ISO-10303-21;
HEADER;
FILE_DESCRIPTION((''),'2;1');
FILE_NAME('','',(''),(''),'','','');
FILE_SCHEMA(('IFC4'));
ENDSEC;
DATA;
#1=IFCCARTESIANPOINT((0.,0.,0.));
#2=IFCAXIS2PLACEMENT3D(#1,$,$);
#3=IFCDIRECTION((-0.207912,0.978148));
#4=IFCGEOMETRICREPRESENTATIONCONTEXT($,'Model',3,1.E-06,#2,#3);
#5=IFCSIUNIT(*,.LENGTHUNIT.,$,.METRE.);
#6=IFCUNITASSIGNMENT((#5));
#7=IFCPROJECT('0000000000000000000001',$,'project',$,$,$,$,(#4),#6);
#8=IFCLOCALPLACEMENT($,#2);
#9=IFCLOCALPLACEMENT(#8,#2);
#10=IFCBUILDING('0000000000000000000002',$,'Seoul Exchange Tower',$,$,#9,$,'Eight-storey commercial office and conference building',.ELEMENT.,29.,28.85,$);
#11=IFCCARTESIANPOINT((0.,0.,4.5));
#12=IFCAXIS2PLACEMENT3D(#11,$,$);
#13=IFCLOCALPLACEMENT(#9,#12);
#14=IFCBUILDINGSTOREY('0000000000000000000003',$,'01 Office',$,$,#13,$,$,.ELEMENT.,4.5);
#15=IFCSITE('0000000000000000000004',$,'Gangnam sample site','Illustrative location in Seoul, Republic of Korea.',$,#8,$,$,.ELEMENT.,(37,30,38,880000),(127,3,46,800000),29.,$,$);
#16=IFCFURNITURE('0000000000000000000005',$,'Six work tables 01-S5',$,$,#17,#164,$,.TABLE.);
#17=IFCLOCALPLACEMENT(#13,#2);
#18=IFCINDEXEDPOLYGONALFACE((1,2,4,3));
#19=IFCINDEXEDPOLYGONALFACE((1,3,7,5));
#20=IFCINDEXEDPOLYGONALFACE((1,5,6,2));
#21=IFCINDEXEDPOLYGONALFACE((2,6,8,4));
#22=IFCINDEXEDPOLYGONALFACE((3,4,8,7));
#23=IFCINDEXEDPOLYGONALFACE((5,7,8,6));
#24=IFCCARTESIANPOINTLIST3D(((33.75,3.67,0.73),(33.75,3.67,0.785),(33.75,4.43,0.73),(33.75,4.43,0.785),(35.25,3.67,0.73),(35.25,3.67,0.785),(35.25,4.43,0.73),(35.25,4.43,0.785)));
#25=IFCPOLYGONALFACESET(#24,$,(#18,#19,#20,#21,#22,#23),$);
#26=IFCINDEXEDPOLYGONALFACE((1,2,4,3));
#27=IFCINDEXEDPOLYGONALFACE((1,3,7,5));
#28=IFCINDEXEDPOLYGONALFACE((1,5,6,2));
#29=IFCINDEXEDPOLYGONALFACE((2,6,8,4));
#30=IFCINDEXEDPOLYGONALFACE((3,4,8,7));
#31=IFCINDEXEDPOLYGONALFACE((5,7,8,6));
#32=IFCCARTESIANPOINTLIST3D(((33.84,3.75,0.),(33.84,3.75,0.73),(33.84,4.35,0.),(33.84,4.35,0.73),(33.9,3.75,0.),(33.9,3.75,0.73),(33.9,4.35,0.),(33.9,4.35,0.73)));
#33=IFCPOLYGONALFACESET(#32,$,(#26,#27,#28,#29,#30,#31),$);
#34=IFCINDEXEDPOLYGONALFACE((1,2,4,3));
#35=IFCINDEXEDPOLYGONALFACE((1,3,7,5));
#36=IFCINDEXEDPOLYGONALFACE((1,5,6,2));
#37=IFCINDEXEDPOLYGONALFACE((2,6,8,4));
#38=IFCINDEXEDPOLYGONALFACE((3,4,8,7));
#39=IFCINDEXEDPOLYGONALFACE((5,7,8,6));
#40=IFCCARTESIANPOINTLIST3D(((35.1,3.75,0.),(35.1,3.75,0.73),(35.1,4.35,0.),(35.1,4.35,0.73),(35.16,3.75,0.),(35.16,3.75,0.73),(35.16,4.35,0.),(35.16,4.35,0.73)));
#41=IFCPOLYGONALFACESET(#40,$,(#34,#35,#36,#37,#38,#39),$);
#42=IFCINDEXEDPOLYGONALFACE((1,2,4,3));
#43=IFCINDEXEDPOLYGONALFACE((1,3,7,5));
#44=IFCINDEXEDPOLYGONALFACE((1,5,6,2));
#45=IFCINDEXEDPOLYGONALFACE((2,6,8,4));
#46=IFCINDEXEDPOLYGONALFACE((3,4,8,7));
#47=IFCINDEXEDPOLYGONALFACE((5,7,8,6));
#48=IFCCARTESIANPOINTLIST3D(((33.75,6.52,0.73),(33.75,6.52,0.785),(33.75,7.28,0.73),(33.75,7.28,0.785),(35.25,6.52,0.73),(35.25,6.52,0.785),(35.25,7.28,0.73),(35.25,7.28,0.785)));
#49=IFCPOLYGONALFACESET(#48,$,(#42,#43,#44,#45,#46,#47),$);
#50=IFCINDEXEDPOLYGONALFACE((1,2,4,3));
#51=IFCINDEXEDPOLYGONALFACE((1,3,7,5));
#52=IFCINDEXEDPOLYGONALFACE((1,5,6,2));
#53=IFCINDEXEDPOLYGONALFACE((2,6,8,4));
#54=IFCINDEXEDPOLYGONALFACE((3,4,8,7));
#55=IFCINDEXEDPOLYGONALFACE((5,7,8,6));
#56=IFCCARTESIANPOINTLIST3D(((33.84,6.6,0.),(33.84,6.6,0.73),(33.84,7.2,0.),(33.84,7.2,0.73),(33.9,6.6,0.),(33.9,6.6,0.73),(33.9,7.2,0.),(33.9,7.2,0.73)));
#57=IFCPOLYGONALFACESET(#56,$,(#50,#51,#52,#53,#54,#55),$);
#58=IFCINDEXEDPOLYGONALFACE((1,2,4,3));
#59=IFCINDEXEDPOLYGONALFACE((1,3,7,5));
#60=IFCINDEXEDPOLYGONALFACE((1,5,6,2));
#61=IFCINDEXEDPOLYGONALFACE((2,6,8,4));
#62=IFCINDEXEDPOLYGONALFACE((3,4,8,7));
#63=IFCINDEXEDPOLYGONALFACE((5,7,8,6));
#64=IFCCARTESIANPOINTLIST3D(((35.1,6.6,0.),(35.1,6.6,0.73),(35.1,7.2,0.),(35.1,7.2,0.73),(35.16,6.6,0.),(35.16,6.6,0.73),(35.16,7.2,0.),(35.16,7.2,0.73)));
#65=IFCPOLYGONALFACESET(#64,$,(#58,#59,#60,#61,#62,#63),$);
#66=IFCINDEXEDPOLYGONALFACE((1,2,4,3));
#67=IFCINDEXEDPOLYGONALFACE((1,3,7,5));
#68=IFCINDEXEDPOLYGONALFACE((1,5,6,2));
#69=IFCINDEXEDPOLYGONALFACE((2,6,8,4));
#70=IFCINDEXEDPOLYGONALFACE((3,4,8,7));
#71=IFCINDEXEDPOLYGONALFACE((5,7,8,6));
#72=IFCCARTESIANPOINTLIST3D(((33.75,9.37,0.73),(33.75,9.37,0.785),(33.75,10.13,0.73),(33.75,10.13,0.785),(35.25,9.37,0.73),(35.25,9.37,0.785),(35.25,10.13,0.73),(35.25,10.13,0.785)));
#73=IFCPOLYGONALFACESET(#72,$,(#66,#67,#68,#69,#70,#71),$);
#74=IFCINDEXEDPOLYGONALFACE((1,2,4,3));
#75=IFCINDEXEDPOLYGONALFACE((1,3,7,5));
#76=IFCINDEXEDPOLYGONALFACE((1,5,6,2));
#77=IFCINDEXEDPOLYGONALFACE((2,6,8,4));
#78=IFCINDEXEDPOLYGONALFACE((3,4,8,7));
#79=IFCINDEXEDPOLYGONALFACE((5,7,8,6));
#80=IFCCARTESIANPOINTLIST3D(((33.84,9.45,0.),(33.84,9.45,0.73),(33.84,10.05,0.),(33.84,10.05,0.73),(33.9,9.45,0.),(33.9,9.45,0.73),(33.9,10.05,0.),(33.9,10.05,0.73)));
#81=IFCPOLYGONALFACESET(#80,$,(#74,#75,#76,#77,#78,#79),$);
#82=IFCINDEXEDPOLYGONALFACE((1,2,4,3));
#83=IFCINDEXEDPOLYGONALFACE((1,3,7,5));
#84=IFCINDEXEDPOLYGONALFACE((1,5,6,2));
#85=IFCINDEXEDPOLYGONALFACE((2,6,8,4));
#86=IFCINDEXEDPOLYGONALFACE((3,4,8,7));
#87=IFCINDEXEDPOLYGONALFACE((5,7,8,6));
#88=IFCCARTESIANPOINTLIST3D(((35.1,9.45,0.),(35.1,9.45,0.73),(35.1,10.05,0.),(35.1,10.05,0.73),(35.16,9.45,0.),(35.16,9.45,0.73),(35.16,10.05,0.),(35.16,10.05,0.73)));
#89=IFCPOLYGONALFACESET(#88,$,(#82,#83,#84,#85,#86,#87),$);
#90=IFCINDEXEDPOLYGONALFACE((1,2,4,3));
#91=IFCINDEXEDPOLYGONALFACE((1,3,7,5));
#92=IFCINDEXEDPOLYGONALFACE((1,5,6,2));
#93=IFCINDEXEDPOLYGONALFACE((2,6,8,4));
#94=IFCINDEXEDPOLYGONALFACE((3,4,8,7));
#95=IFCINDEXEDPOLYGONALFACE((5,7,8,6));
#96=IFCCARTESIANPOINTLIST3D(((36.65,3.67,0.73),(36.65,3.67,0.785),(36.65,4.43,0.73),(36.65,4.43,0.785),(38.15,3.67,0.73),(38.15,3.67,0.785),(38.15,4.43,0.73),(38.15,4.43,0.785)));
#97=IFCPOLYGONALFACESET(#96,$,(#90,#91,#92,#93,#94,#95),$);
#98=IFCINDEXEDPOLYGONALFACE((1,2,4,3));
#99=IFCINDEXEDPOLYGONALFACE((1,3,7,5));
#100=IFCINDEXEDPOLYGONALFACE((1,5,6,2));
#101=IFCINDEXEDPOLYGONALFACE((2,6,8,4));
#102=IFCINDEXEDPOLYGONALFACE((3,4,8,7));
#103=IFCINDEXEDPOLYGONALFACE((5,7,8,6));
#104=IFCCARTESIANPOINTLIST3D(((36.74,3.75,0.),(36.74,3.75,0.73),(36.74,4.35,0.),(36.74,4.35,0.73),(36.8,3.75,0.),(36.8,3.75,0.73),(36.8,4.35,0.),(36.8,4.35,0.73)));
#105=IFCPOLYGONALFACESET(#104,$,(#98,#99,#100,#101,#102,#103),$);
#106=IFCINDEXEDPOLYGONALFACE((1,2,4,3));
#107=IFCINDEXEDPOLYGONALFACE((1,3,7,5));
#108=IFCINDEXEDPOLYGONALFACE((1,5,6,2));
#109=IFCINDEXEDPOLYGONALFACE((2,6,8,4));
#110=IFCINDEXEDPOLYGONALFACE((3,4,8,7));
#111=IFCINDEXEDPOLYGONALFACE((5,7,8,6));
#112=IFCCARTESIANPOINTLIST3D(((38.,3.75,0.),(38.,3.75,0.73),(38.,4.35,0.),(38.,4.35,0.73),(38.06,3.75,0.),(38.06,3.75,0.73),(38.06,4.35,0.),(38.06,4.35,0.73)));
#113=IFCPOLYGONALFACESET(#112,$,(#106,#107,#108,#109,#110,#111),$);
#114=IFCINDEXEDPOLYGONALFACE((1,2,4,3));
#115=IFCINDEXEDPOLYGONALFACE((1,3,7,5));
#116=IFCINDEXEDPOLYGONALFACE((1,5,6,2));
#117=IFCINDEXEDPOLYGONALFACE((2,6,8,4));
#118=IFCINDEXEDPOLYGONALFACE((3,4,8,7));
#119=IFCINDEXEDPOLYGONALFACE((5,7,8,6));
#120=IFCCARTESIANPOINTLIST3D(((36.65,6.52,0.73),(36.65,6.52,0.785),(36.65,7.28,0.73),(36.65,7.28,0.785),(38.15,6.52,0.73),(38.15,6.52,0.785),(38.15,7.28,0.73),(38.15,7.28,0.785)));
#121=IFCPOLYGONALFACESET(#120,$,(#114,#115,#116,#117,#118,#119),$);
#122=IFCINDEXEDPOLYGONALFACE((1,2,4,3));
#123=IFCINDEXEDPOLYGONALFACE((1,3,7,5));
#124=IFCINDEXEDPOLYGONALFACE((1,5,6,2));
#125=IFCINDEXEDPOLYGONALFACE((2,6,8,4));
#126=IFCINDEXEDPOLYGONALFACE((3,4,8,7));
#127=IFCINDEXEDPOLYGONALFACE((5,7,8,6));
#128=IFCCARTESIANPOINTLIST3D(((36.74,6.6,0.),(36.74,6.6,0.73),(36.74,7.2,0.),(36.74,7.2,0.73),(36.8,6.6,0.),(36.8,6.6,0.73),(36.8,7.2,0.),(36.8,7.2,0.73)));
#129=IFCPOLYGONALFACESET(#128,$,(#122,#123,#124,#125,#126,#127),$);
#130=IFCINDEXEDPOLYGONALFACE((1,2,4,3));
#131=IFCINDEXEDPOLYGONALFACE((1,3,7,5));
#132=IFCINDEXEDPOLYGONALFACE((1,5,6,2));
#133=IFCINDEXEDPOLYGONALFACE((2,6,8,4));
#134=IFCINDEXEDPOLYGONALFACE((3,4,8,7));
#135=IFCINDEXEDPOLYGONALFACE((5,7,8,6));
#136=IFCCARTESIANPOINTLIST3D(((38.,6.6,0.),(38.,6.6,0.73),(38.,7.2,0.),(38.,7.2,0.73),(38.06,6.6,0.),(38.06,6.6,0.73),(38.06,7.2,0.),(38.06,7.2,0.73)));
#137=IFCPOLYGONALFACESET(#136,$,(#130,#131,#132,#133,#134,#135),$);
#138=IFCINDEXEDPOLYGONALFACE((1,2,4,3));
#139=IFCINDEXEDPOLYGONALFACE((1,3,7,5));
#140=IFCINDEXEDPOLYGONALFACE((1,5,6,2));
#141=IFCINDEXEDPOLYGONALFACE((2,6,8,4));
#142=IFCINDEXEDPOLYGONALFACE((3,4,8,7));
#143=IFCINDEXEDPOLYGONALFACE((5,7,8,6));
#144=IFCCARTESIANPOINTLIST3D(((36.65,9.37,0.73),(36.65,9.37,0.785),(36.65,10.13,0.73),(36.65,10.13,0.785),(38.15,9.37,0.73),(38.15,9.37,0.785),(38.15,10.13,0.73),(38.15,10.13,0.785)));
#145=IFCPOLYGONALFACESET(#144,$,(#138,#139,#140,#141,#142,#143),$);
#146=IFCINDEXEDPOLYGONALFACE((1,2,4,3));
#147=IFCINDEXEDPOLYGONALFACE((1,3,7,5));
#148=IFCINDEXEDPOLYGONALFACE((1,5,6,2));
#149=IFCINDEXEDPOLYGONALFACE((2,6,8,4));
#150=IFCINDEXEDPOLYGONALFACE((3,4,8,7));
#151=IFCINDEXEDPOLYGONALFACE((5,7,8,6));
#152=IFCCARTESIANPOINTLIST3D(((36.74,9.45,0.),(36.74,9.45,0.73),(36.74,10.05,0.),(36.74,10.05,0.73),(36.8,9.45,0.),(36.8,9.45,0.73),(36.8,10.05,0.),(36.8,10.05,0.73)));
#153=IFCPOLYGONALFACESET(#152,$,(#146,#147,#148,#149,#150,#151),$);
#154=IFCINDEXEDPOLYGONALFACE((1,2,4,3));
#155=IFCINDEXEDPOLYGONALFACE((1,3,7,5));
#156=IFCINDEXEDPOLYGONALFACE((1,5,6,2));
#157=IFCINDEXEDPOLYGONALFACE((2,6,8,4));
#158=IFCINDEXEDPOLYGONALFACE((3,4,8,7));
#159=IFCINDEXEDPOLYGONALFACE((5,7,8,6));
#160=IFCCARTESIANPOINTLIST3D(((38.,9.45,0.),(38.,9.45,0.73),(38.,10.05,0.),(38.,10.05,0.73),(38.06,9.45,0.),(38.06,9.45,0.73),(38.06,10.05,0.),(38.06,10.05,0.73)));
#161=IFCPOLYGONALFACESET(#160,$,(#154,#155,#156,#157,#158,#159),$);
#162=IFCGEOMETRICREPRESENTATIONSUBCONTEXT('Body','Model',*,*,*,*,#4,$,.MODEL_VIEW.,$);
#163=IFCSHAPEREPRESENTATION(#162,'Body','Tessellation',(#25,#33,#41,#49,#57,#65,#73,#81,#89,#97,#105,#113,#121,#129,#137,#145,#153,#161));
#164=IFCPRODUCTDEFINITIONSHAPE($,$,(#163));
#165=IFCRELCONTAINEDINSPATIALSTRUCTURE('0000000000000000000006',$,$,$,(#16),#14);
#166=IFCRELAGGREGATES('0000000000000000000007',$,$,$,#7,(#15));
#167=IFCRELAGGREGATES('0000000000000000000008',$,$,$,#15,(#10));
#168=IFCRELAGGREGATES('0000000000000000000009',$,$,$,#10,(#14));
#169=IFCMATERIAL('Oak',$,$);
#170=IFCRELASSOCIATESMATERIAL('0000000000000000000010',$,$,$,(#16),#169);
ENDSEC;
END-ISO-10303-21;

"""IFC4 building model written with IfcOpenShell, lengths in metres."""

from ifc_helpers import new_model, si_unit, direction, frame, frame_2d, origin, place, context, subcontext, project, spatial, rectangle, extrude, material, element, save


model = new_model("IFC4")

# Units and contexts
model_context = context("Model", 3, precision=1e-06, world=origin(), true_north=direction((-0.207912, 0.978148)))
body_context = subcontext(model_context, "Body", "Model", "MODEL_VIEW")
ifc_project = project(units=[si_unit("LENGTHUNIT", "METRE")], contexts=[model_context])

# Site, building, storey
site_placement = place(None, origin())
site = spatial("IfcSite", under=ifc_project, at=site_placement, Name="Gangnam sample site", Description="Illustrative location in Seoul, Republic of Korea.", CompositionType="ELEMENT", RefLatitude=(37, 30, 38, 880000), RefLongitude=(127, 3, 46, 800000), RefElevation=29.0)
building_placement = place(site_placement, origin())
building = spatial("IfcBuilding", under=site, at=building_placement, Name="Seoul Exchange Tower", LongName="Eight-storey commercial office and conference building", CompositionType="ELEMENT", ElevationOfRefHeight=29.0, ElevationOfTerrain=28.85)
storey_placement = place(building_placement, frame((0.0, 0.0, 4.5)))
storey = spatial("IfcBuildingStorey", under=building, at=storey_placement, Name="01 Office", CompositionType="ELEMENT", Elevation=4.5)

# Shared definitions
placement = place(storey_placement, origin())

# Furniture
ifc_material_1 = material(Name="Oak")
element("IfcFurniture", 1, at=placement, inside=storey, material=ifc_material_1, Name="Six work tables 01-S5", PredefinedType="TABLE", context=body_context, shape_type="SweptSolid", body=[
    extrude(rectangle(XDim=1.5, YDim=0.76, at=frame_2d((0.75, 0.38))), frame((33.75, 3.67, 0.73)), (0.0, 0.0, 1.0), 0.055),
    extrude(rectangle(XDim=0.06, YDim=0.6, at=frame_2d((0.03, 0.3))), frame((33.84, 3.75, 0.0)), (0.0, 0.0, 1.0), 0.73),
    extrude(rectangle(XDim=0.06, YDim=0.6, at=frame_2d((0.03, 0.3))), frame((35.1, 3.75, 0.0)), (0.0, 0.0, 1.0), 0.73),
    extrude(rectangle(XDim=1.5, YDim=0.76, at=frame_2d((0.75, 0.38))), frame((33.75, 6.52, 0.73)), (0.0, 0.0, 1.0), 0.055),
    extrude(rectangle(XDim=0.06, YDim=0.6, at=frame_2d((0.03, 0.3))), frame((33.84, 6.6, 0.0)), (0.0, 0.0, 1.0), 0.73),
    extrude(rectangle(XDim=0.06, YDim=0.6, at=frame_2d((0.03, 0.3))), frame((35.1, 6.6, 0.0)), (0.0, 0.0, 1.0), 0.73),
    extrude(rectangle(XDim=1.5, YDim=0.76, at=frame_2d((0.75, 0.38))), frame((33.75, 9.37, 0.73)), (0.0, 0.0, 1.0), 0.055),
    extrude(rectangle(XDim=0.06, YDim=0.6, at=frame_2d((0.03, 0.3))), frame((33.84, 9.45, 0.0)), (0.0, 0.0, 1.0), 0.73),
    extrude(rectangle(XDim=0.06, YDim=0.6, at=frame_2d((0.03, 0.3))), frame((35.1, 9.45, 0.0)), (0.0, 0.0, 1.0), 0.73),
    extrude(rectangle(XDim=1.5, YDim=0.76, at=frame_2d((0.75, 0.38))), frame((36.65, 3.67, 0.73)), (0.0, 0.0, 1.0), 0.055),
    extrude(rectangle(XDim=0.06, YDim=0.6, at=frame_2d((0.03, 0.3))), frame((36.74, 3.75, 0.0)), (0.0, 0.0, 1.0), 0.73),
    extrude(rectangle(XDim=0.06, YDim=0.6, at=frame_2d((0.03, 0.3))), frame((38.0, 3.75, 0.0)), (0.0, 0.0, 1.0), 0.73),
    extrude(rectangle(XDim=1.5, YDim=0.76, at=frame_2d((0.75, 0.38))), frame((36.65, 6.52, 0.73)), (0.0, 0.0, 1.0), 0.055),
    extrude(rectangle(XDim=0.06, YDim=0.6, at=frame_2d((0.03, 0.3))), frame((36.74, 6.6, 0.0)), (0.0, 0.0, 1.0), 0.73),
    extrude(rectangle(XDim=0.06, YDim=0.6, at=frame_2d((0.03, 0.3))), frame((38.0, 6.6, 0.0)), (0.0, 0.0, 1.0), 0.73),
    extrude(rectangle(XDim=1.5, YDim=0.76, at=frame_2d((0.75, 0.38))), frame((36.65, 9.37, 0.73)), (0.0, 0.0, 1.0), 0.055),
    extrude(rectangle(XDim=0.06, YDim=0.6, at=frame_2d((0.03, 0.3))), frame((36.74, 9.45, 0.0)), (0.0, 0.0, 1.0), 0.73),
    extrude(rectangle(XDim=0.06, YDim=0.6, at=frame_2d((0.03, 0.3))), frame((38.0, 9.45, 0.0)), (0.0, 0.0, 1.0), 0.73),
])

save(model, "model.ifc")
